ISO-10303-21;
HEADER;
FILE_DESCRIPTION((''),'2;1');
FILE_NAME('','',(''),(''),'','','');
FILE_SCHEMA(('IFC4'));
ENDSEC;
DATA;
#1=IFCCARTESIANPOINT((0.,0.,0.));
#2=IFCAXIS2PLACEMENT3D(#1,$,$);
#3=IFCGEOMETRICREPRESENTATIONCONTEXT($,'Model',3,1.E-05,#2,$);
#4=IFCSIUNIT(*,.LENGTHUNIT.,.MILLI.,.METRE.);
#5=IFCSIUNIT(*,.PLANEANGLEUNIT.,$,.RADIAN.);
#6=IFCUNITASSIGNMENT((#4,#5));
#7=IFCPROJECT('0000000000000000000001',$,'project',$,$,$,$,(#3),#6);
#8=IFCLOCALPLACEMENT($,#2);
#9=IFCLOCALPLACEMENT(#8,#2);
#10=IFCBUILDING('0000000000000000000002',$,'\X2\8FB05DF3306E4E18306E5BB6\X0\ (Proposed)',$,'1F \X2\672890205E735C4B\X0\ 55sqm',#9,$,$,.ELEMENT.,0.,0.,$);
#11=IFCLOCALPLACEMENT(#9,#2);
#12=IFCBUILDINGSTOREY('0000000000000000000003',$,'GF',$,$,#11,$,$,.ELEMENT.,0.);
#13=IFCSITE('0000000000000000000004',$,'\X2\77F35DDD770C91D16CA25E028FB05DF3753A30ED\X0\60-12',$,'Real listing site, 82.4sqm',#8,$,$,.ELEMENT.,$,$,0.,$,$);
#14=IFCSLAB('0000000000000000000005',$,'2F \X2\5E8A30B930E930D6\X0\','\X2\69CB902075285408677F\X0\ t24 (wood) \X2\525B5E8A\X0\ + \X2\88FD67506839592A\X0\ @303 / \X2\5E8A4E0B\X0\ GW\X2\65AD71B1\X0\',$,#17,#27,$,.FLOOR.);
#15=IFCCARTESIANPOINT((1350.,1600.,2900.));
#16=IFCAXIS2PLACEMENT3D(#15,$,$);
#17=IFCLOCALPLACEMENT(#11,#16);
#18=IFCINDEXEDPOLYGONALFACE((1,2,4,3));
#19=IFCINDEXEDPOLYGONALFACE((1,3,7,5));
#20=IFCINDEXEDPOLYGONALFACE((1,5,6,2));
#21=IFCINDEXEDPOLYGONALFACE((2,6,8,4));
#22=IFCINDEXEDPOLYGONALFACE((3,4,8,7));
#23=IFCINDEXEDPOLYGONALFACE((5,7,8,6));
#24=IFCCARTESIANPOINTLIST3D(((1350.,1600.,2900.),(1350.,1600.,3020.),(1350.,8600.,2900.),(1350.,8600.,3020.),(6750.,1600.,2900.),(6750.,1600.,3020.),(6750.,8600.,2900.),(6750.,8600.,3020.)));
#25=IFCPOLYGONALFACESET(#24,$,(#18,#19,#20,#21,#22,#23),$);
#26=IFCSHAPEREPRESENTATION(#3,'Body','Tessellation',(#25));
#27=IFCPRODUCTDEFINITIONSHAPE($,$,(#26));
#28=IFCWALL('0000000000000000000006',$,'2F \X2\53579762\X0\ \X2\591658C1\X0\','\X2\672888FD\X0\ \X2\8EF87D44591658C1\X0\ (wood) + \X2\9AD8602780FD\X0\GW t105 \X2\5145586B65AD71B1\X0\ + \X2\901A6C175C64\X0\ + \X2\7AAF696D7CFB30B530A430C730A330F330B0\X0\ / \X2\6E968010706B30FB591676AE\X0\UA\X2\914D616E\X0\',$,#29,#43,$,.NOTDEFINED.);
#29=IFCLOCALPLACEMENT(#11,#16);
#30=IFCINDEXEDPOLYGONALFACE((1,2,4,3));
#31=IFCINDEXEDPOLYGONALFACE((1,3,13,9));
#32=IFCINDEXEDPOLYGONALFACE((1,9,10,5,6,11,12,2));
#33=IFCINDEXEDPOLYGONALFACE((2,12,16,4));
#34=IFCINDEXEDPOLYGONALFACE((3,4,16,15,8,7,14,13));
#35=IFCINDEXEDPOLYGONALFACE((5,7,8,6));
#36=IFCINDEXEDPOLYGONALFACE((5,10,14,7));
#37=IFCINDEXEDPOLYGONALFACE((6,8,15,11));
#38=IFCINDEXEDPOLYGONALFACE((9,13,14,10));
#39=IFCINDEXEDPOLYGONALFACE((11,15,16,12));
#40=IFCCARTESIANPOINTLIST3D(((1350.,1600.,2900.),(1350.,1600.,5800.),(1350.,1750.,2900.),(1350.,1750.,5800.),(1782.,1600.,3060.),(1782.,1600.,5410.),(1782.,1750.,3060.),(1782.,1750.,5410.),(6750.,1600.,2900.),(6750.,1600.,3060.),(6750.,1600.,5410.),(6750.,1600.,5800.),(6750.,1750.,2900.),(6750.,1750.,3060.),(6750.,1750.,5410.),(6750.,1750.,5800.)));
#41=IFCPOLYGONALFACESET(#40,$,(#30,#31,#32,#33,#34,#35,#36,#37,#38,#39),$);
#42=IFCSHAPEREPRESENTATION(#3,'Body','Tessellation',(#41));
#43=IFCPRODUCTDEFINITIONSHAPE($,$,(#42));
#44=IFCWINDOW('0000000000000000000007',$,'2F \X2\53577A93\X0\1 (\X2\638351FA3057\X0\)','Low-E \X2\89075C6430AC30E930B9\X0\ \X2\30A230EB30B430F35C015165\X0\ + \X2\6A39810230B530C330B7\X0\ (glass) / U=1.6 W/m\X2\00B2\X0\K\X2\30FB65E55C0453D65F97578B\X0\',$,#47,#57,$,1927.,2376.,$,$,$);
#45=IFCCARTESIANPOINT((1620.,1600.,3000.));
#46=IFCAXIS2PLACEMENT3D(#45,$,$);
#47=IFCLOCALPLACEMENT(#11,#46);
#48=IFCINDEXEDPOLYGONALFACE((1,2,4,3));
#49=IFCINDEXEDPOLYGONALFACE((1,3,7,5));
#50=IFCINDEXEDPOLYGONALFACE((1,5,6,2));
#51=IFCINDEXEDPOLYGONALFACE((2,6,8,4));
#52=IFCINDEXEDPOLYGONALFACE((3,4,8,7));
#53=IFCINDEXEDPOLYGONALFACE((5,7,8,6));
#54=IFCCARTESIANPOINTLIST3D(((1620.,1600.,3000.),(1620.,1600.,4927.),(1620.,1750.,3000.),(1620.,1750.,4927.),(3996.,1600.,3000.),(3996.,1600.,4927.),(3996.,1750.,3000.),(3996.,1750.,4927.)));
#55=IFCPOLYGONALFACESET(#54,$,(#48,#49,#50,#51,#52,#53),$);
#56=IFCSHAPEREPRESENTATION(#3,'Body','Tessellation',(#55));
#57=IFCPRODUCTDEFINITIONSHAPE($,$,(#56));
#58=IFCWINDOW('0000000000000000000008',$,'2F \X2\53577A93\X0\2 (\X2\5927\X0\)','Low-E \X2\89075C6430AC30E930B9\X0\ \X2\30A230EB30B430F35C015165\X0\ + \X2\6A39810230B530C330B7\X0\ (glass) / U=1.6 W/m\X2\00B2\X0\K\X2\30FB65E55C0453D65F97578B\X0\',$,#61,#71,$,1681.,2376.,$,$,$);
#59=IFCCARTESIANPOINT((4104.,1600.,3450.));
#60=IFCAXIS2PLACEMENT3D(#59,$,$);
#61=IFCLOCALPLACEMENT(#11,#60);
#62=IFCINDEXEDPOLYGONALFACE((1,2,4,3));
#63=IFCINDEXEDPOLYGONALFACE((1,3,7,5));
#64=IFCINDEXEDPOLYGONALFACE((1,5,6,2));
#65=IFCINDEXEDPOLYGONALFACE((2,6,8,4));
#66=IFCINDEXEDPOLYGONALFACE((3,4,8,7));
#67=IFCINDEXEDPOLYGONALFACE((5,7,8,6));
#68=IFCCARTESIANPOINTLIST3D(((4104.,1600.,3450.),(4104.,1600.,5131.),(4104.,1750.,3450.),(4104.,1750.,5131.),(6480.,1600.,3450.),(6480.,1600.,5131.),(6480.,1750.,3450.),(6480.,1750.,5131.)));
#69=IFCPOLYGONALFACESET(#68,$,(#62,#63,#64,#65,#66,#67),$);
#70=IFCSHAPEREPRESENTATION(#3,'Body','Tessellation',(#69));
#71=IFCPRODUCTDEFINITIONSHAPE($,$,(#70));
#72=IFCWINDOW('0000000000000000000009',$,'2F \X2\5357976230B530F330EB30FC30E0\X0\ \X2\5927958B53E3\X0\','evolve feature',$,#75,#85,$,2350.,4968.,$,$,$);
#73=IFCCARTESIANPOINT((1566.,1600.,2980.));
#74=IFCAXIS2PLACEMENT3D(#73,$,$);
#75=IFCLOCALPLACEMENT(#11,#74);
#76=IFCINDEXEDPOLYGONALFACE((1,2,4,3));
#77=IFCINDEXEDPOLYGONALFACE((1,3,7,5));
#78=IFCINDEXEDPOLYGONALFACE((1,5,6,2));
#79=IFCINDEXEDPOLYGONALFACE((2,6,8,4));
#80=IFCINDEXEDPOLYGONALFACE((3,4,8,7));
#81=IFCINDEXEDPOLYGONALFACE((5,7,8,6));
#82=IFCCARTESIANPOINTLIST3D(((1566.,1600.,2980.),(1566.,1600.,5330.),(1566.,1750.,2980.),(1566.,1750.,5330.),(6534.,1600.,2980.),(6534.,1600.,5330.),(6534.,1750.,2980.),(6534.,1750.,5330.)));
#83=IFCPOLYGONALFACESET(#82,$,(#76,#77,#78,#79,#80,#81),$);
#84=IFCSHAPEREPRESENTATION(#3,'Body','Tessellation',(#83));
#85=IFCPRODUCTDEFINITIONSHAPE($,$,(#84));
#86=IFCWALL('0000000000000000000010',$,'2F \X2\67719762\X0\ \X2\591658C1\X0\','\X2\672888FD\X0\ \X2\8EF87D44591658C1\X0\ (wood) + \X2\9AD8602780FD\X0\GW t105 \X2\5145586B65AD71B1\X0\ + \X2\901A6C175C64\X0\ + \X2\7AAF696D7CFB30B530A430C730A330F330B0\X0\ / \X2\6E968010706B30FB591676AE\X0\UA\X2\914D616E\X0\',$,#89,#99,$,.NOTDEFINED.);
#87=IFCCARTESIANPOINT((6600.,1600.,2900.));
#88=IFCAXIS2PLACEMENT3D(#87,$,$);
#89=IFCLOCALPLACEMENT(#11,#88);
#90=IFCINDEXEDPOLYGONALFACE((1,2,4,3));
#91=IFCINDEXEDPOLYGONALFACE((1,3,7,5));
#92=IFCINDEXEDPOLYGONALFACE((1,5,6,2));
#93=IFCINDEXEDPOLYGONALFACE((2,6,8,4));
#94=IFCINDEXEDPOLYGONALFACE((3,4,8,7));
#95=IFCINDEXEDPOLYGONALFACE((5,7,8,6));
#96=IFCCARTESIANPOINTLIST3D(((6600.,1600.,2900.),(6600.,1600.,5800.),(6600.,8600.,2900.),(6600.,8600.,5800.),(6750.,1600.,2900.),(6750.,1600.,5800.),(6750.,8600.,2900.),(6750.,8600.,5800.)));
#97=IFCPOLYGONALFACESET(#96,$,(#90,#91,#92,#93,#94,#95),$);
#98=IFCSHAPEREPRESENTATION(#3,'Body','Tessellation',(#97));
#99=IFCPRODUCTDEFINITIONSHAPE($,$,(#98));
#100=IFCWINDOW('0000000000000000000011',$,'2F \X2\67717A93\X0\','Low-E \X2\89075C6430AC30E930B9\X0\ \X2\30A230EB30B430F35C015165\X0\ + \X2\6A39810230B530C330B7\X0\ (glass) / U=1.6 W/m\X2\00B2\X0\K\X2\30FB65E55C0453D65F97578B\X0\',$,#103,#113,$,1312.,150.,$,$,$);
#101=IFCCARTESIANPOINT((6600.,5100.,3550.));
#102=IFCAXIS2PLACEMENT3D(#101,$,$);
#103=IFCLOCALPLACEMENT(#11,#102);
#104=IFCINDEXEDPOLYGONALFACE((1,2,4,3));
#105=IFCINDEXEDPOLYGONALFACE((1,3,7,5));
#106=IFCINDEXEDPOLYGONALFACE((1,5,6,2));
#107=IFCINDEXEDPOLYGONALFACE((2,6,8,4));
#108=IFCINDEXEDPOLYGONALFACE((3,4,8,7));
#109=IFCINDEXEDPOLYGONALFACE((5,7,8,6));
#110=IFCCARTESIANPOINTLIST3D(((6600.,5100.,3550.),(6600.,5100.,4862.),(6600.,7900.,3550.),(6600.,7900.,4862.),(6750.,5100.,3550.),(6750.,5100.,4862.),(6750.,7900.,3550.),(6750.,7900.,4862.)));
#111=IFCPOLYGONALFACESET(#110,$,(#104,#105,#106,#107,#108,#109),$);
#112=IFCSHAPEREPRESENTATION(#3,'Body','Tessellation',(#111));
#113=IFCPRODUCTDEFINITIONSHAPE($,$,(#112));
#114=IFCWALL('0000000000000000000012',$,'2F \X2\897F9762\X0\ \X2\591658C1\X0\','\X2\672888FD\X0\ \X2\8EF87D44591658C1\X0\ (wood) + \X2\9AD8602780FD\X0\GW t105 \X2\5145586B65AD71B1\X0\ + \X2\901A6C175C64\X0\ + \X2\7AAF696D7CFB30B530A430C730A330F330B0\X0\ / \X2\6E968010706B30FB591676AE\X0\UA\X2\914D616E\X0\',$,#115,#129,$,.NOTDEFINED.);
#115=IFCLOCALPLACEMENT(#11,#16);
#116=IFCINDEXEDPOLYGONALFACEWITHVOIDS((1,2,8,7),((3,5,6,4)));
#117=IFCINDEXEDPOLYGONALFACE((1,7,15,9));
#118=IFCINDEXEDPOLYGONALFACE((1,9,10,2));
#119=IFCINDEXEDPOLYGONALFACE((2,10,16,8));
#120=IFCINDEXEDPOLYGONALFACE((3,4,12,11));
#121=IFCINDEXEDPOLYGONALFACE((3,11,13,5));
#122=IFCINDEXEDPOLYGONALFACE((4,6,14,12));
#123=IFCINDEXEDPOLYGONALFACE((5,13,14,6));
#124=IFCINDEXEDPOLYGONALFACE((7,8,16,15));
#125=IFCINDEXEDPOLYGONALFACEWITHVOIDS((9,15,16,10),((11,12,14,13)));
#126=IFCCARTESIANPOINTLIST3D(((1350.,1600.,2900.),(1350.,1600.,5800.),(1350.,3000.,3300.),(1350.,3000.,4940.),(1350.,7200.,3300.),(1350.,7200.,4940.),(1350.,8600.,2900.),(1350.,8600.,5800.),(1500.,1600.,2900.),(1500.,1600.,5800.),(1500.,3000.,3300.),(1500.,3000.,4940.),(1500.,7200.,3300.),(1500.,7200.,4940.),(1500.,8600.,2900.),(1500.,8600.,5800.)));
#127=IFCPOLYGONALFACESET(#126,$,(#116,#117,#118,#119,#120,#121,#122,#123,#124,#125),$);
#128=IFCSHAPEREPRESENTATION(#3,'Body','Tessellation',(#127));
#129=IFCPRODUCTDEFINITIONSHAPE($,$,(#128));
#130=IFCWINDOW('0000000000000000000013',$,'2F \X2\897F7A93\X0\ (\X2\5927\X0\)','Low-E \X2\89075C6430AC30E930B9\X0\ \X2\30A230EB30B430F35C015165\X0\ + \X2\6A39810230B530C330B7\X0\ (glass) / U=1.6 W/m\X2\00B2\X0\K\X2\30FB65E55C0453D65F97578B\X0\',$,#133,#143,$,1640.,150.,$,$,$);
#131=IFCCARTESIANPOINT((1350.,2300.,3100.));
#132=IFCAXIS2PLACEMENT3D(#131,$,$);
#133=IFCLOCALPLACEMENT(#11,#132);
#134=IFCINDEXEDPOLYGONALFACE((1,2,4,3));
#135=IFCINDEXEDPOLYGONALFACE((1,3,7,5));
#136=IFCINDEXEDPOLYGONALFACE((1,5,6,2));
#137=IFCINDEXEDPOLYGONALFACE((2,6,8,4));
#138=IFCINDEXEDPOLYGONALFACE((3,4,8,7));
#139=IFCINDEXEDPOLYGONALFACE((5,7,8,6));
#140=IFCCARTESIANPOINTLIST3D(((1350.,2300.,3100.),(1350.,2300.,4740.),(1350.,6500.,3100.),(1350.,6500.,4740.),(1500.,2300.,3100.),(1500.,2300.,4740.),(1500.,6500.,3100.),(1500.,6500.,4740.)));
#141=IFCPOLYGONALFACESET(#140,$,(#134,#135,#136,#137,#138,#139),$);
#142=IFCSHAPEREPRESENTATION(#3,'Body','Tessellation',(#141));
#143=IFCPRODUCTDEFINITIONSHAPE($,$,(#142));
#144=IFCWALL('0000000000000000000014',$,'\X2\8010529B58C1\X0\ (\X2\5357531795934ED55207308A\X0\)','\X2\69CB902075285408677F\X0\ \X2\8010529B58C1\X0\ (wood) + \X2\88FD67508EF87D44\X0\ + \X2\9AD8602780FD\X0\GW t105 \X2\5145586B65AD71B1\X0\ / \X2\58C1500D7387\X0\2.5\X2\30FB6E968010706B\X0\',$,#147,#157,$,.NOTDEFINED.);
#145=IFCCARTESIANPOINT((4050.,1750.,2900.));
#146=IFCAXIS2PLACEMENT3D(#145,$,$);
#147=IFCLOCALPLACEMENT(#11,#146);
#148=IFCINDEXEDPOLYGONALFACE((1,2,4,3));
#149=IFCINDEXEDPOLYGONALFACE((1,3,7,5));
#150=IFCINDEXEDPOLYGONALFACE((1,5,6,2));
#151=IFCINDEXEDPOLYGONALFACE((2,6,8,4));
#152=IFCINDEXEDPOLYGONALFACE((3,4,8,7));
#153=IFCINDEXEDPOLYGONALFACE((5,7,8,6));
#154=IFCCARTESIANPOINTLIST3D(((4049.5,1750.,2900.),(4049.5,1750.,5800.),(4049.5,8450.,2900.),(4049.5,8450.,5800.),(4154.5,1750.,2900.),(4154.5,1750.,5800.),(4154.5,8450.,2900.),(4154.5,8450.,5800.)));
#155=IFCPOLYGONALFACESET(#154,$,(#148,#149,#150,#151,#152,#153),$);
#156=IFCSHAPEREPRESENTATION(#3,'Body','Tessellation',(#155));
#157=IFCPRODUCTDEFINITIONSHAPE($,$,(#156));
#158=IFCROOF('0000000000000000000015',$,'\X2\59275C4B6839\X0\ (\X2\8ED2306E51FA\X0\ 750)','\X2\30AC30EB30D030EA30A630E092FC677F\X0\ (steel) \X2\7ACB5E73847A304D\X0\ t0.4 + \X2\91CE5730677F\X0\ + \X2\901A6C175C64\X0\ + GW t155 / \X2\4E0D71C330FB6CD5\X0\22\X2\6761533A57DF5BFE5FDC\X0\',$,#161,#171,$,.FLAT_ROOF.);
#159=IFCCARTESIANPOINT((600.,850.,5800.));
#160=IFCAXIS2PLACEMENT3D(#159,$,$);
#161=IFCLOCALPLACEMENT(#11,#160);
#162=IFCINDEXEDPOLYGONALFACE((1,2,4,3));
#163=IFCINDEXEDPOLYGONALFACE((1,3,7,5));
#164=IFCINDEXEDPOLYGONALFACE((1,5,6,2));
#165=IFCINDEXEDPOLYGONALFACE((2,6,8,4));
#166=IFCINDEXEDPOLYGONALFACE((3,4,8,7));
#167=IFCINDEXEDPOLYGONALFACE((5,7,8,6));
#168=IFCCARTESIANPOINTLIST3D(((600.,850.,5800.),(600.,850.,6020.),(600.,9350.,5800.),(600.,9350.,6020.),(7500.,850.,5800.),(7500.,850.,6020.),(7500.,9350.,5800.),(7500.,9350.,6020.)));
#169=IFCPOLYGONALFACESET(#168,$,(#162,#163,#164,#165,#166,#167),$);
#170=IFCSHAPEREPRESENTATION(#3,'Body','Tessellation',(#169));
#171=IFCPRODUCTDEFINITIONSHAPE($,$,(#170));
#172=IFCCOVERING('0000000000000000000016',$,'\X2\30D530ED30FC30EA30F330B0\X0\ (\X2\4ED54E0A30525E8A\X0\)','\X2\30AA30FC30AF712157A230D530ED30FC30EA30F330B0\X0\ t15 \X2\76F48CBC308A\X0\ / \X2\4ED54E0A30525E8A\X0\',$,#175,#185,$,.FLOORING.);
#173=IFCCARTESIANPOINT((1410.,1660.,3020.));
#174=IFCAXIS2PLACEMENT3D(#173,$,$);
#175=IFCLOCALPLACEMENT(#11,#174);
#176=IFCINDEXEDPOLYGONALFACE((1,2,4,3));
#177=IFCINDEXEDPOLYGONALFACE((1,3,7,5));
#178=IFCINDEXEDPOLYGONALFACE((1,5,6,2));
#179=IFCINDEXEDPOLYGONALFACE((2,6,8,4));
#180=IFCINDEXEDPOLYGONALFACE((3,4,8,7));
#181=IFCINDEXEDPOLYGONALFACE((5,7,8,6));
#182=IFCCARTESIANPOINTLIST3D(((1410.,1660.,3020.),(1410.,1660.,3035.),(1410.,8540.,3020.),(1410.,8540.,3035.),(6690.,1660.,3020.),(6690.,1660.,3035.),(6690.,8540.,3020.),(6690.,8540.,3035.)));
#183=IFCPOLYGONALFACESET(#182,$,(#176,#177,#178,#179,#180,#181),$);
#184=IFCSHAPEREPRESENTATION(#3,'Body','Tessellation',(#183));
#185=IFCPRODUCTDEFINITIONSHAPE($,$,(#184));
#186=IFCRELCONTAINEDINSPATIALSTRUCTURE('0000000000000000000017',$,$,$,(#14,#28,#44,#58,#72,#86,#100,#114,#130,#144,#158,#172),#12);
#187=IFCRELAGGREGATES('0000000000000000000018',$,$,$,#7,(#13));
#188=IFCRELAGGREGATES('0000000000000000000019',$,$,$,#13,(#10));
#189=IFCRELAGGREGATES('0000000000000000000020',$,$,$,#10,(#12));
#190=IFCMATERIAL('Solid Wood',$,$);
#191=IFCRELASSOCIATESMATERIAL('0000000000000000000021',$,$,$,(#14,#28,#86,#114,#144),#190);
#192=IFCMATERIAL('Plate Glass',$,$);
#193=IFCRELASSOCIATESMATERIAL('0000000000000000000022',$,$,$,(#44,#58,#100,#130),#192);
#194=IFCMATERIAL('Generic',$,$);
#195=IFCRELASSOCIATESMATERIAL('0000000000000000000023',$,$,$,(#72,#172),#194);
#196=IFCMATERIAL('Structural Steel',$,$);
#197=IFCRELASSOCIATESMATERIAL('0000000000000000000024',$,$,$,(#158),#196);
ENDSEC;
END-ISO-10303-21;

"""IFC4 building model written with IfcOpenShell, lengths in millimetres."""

from ifc_helpers import new_model, si_unit, frame, frame_2d, origin, place, context, project, spatial, rectangle, extrude, material, element, fill, save


model = new_model("IFC4")

# Units and contexts
model_context = context("Model", 3, precision=1e-05, world=origin())
ifc_project = project(units=[si_unit("LENGTHUNIT", "METRE", prefix="MILLI"), si_unit("PLANEANGLEUNIT", "RADIAN")], contexts=[model_context])

# Site, building, storey
site_placement = place(None, origin())
site = spatial("IfcSite", under=ifc_project, at=site_placement, Name="石川県金沢市辰巳町ロ60-12", ObjectType="Real listing site, 82.4sqm", CompositionType="ELEMENT", RefElevation=0.0)
building_placement = place(site_placement, origin())
building = spatial("IfcBuilding", under=site, at=building_placement, Name="辰巳の丘の家 (Proposed)", ObjectType="1F 木造平屋 55sqm", CompositionType="ELEMENT", ElevationOfRefHeight=0.0, ElevationOfTerrain=0.0)
storey_placement = place(building_placement, origin())
storey = spatial("IfcBuildingStorey", under=building, at=storey_placement, Name="GF", CompositionType="ELEMENT", Elevation=0.0)

# Slab
ifc_material_1 = material(Name="Solid Wood")
slab_placement = place(storey_placement, frame((1350.0, 1600.0, 2900.0)))
element("IfcSlab", 1, at=slab_placement, inside=storey, material=ifc_material_1, Name="2F 床スラブ", Description="構造用合板 t24 (wood) 剛床 + 製材根太 @303 / 床下 GW断熱", PredefinedType="FLOOR", context=model_context, shape_type="SweptSolid", body=[
    extrude(rectangle(XDim=5400.0, YDim=7000.0, at=frame_2d((2700.0, 3500.0))), frame((1350.0, 1600.0, 2900.0)), (0.0, 0.0, 1.0), 120.0),
])

# Wall, openings, windows
wall_1_placement = place(storey_placement, frame((1350.0, 1600.0, 2900.0)))
wall_1 = element("IfcWall", 2, at=wall_1_placement, inside=storey, material=ifc_material_1, Name="2F 南面 外壁", Description="木製 軸組外壁 (wood) + 高性能GW t105 充填断熱 + 通気層 + 窯業系サイディング / 準耐火・外皮UA配慮", PredefinedType="NOTDEFINED", context=model_context, shape_type="SweptSolid", body=[
    extrude(rectangle(XDim=5400.0, YDim=150.0, at=frame_2d((2700.0, 75.0))), frame((1350.0, 1600.0, 2900.0)), (0.0, 0.0, 1.0), 2900.0),
])
opening_1_placement = place(storey_placement, frame((1620.0, 1600.0, 3000.0)))
opening_1 = element("IfcOpeningElement", 3, at=opening_1_placement, cuts=wall_1, PredefinedType="NOTDEFINED", context=model_context, shape_type="SweptSolid", body=[
    extrude(rectangle(XDim=2376.0, YDim=150.0, at=frame_2d((1188.0, 75.0))), frame((1620.0, 1600.0, 3000.0)), (0.0, 0.0, 1.0), 1927.0),
])
opening_2_placement = place(storey_placement, frame((4104.0, 1600.0, 3450.0)))
opening_2 = element("IfcOpeningElement", 4, at=opening_2_placement, cuts=wall_1, PredefinedType="NOTDEFINED", context=model_context, shape_type="SweptSolid", body=[
    extrude(rectangle(XDim=2376.0, YDim=150.0, at=frame_2d((1188.0, 75.0))), frame((4104.0, 1600.0, 3450.0)), (0.0, 0.0, 1.0), 1681.0),
])
opening_3_placement = place(storey_placement, frame((1566.0, 1600.0, 2980.0)))
opening_3 = element("IfcOpeningElement", 5, at=opening_3_placement, cuts=wall_1, PredefinedType="NOTDEFINED", context=model_context, shape_type="SweptSolid", body=[
    extrude(rectangle(XDim=4968.0, YDim=150.0, at=frame_2d((2484.0, 75.0))), frame((1566.0, 1600.0, 2980.0)), (0.0, 0.0, 1.0), 2350.0),
])
ifc_material_2 = material(Name="Plate Glass")
window_1_placement = place(storey_placement, frame((1620.0, 1600.0, 3000.0)))
window_1 = element("IfcWindow", 6, at=window_1_placement, inside=storey, material=ifc_material_2, Name="2F 南窓1 (掃出し)", Description="Low-E 複層ガラス アルゴン封入 + 樹脂サッシ (glass) / U=1.6 W/m²K・日射取得型", OverallHeight=1927.0, OverallWidth=2376.0, context=model_context, shape_type="SweptSolid", body=[
    extrude(rectangle(XDim=2376.0, YDim=150.0, at=frame_2d((1188.0, 75.0))), frame((1620.0, 1600.0, 3000.0)), (0.0, 0.0, 1.0), 1927.0),
])
fill(opening_1, window_1)
window_2_placement = place(storey_placement, frame((4104.0, 1600.0, 3450.0)))
window_2 = element("IfcWindow", 7, at=window_2_placement, inside=storey, material=ifc_material_2, Name="2F 南窓2 (大)", Description="Low-E 複層ガラス アルゴン封入 + 樹脂サッシ (glass) / U=1.6 W/m²K・日射取得型", OverallHeight=1681.0, OverallWidth=2376.0, context=model_context, shape_type="SweptSolid", body=[
    extrude(rectangle(XDim=2376.0, YDim=150.0, at=frame_2d((1188.0, 75.0))), frame((4104.0, 1600.0, 3450.0)), (0.0, 0.0, 1.0), 1681.0),
])
fill(opening_2, window_2)
ifc_material_3 = material(Name="Generic")
window_3_placement = place(storey_placement, frame((1566.0, 1600.0, 2980.0)))
window_3 = element("IfcWindow", 8, at=window_3_placement, inside=storey, material=ifc_material_3, Name="2F 南面サンルーム 大開口", Description="evolve feature", OverallHeight=2350.0, OverallWidth=4968.0, context=model_context, shape_type="SweptSolid", body=[
    extrude(rectangle(XDim=4968.0, YDim=150.0, at=frame_2d((2484.0, 75.0))), frame((1566.0, 1600.0, 2980.0)), (0.0, 0.0, 1.0), 2350.0),
])
fill(opening_3, window_3)

# Walls, openings, windows
wall_2_placement = place(storey_placement, frame((6600.0, 1600.0, 2900.0)))
wall_2 = element("IfcWall", 9, at=wall_2_placement, inside=storey, material=ifc_material_1, Name="2F 東面 外壁", Description="木製 軸組外壁 (wood) + 高性能GW t105 充填断熱 + 通気層 + 窯業系サイディング / 準耐火・外皮UA配慮", PredefinedType="NOTDEFINED", context=model_context, shape_type="SweptSolid", body=[
    extrude(rectangle(XDim=150.0, YDim=7000.0, at=frame_2d((75.0, 3500.0))), frame((6600.0, 1600.0, 2900.0)), (0.0, 0.0, 1.0), 2900.0),
])
opening_4_placement = place(storey_placement, frame((6600.0, 5100.0, 3550.0)))
opening_4 = element("IfcOpeningElement", 10, at=opening_4_placement, cuts=wall_2, PredefinedType="NOTDEFINED", context=model_context, shape_type="SweptSolid", body=[
    extrude(rectangle(XDim=150.0, YDim=2800.0, at=frame_2d((75.0, 1400.0))), frame((6600.0, 5100.0, 3550.0)), (0.0, 0.0, 1.0), 1312.0),
])
window_4_placement = place(storey_placement, frame((6600.0, 5100.0, 3550.0)))
window_4 = element("IfcWindow", 11, at=window_4_placement, inside=storey, material=ifc_material_2, Name="2F 東窓", Description="Low-E 複層ガラス アルゴン封入 + 樹脂サッシ (glass) / U=1.6 W/m²K・日射取得型", OverallHeight=1312.0, OverallWidth=150.0, context=model_context, shape_type="SweptSolid", body=[
    extrude(rectangle(XDim=150.0, YDim=2800.0, at=frame_2d((75.0, 1400.0))), frame((6600.0, 5100.0, 3550.0)), (0.0, 0.0, 1.0), 1312.0),
])
fill(opening_4, window_4)
wall_3_placement = place(storey_placement, frame((1350.0, 1600.0, 2900.0)))
wall_3 = element("IfcWall", 12, at=wall_3_placement, inside=storey, material=ifc_material_1, Name="2F 西面 外壁", Description="木製 軸組外壁 (wood) + 高性能GW t105 充填断熱 + 通気層 + 窯業系サイディング / 準耐火・外皮UA配慮", PredefinedType="NOTDEFINED", context=model_context, shape_type="SweptSolid", body=[
    extrude(rectangle(XDim=150.0, YDim=7000.0, at=frame_2d((75.0, 3500.0))), frame((1350.0, 1600.0, 2900.0)), (0.0, 0.0, 1.0), 2900.0),
])
opening_5_placement = place(storey_placement, frame((1350.0, 2300.0, 3100.0)))
opening_5 = element("IfcOpeningElement", 13, at=opening_5_placement, cuts=wall_3, PredefinedType="NOTDEFINED", context=model_context, shape_type="SweptSolid", body=[
    extrude(rectangle(XDim=150.0, YDim=4200.0, at=frame_2d((75.0, 2100.0))), frame((1350.0, 2300.0, 3100.0)), (0.0, 0.0, 1.0), 1640.0),
])
window_5_placement = place(storey_placement, frame((1350.0, 2300.0, 3100.0)))
window_5 = element("IfcWindow", 14, at=window_5_placement, inside=storey, material=ifc_material_2, Name="2F 西窓 (大)", Description="Low-E 複層ガラス アルゴン封入 + 樹脂サッシ (glass) / U=1.6 W/m²K・日射取得型", OverallHeight=1640.0, OverallWidth=150.0, context=model_context, shape_type="SweptSolid", body=[
    extrude(rectangle(XDim=150.0, YDim=4200.0, at=frame_2d((75.0, 2100.0))), frame((1350.0, 2300.0, 3100.0)), (0.0, 0.0, 1.0), 1640.0),
])
fill(opening_5, window_5)

# Wall
wall_4_placement = place(storey_placement, frame((4050.0, 1750.0, 2900.0)))
element("IfcWall", 15, at=wall_4_placement, inside=storey, material=ifc_material_1, Name="耐力壁 (南北間仕切り)", Description="構造用合板 耐力壁 (wood) + 製材軸組 + 高性能GW t105 充填断熱 / 壁倍率2.5・準耐火", PredefinedType="NOTDEFINED", context=model_context, shape_type="SweptSolid", body=[
    extrude(rectangle(XDim=105.0, YDim=6700.0, at=frame_2d((52.0, 3350.0))), frame((4050.0, 1750.0, 2900.0)), (0.0, 0.0, 1.0), 2900.0),
])

# Roof
ifc_material_4 = material(Name="Structural Steel")
roof_placement = place(storey_placement, frame((600.0, 850.0, 5800.0)))
element("IfcRoof", 16, at=roof_placement, inside=storey, material=ifc_material_4, Name="大屋根 (軒の出 750)", Description="ガルバリウム鋼板 (steel) 立平葺き t0.4 + 野地板 + 通気層 + GW t155 / 不燃・法22条区域対応", PredefinedType="FLAT_ROOF", context=model_context, shape_type="SweptSolid", body=[
    extrude(rectangle(XDim=6900.0, YDim=8500.0, at=frame_2d((3450.0, 4250.0))), frame((600.0, 850.0, 5800.0)), (0.0, 0.0, 1.0), 220.0),
])

# Covering
covering_placement = place(storey_placement, frame((1410.0, 1660.0, 3020.0)))
element("IfcCovering", 17, at=covering_placement, inside=storey, material=ifc_material_3, Name="フローリング (仕上げ床)", Description="オーク無垢フローリング t15 直貼り / 仕上げ床", PredefinedType="FLOORING", context=model_context, shape_type="SweptSolid", body=[
    extrude(rectangle(XDim=5280.0, YDim=6880.0, at=frame_2d((2640.0, 3440.0))), frame((1410.0, 1660.0, 3020.0)), (0.0, 0.0, 1.0), 15.0),
])

save(model, "model.ifc")
